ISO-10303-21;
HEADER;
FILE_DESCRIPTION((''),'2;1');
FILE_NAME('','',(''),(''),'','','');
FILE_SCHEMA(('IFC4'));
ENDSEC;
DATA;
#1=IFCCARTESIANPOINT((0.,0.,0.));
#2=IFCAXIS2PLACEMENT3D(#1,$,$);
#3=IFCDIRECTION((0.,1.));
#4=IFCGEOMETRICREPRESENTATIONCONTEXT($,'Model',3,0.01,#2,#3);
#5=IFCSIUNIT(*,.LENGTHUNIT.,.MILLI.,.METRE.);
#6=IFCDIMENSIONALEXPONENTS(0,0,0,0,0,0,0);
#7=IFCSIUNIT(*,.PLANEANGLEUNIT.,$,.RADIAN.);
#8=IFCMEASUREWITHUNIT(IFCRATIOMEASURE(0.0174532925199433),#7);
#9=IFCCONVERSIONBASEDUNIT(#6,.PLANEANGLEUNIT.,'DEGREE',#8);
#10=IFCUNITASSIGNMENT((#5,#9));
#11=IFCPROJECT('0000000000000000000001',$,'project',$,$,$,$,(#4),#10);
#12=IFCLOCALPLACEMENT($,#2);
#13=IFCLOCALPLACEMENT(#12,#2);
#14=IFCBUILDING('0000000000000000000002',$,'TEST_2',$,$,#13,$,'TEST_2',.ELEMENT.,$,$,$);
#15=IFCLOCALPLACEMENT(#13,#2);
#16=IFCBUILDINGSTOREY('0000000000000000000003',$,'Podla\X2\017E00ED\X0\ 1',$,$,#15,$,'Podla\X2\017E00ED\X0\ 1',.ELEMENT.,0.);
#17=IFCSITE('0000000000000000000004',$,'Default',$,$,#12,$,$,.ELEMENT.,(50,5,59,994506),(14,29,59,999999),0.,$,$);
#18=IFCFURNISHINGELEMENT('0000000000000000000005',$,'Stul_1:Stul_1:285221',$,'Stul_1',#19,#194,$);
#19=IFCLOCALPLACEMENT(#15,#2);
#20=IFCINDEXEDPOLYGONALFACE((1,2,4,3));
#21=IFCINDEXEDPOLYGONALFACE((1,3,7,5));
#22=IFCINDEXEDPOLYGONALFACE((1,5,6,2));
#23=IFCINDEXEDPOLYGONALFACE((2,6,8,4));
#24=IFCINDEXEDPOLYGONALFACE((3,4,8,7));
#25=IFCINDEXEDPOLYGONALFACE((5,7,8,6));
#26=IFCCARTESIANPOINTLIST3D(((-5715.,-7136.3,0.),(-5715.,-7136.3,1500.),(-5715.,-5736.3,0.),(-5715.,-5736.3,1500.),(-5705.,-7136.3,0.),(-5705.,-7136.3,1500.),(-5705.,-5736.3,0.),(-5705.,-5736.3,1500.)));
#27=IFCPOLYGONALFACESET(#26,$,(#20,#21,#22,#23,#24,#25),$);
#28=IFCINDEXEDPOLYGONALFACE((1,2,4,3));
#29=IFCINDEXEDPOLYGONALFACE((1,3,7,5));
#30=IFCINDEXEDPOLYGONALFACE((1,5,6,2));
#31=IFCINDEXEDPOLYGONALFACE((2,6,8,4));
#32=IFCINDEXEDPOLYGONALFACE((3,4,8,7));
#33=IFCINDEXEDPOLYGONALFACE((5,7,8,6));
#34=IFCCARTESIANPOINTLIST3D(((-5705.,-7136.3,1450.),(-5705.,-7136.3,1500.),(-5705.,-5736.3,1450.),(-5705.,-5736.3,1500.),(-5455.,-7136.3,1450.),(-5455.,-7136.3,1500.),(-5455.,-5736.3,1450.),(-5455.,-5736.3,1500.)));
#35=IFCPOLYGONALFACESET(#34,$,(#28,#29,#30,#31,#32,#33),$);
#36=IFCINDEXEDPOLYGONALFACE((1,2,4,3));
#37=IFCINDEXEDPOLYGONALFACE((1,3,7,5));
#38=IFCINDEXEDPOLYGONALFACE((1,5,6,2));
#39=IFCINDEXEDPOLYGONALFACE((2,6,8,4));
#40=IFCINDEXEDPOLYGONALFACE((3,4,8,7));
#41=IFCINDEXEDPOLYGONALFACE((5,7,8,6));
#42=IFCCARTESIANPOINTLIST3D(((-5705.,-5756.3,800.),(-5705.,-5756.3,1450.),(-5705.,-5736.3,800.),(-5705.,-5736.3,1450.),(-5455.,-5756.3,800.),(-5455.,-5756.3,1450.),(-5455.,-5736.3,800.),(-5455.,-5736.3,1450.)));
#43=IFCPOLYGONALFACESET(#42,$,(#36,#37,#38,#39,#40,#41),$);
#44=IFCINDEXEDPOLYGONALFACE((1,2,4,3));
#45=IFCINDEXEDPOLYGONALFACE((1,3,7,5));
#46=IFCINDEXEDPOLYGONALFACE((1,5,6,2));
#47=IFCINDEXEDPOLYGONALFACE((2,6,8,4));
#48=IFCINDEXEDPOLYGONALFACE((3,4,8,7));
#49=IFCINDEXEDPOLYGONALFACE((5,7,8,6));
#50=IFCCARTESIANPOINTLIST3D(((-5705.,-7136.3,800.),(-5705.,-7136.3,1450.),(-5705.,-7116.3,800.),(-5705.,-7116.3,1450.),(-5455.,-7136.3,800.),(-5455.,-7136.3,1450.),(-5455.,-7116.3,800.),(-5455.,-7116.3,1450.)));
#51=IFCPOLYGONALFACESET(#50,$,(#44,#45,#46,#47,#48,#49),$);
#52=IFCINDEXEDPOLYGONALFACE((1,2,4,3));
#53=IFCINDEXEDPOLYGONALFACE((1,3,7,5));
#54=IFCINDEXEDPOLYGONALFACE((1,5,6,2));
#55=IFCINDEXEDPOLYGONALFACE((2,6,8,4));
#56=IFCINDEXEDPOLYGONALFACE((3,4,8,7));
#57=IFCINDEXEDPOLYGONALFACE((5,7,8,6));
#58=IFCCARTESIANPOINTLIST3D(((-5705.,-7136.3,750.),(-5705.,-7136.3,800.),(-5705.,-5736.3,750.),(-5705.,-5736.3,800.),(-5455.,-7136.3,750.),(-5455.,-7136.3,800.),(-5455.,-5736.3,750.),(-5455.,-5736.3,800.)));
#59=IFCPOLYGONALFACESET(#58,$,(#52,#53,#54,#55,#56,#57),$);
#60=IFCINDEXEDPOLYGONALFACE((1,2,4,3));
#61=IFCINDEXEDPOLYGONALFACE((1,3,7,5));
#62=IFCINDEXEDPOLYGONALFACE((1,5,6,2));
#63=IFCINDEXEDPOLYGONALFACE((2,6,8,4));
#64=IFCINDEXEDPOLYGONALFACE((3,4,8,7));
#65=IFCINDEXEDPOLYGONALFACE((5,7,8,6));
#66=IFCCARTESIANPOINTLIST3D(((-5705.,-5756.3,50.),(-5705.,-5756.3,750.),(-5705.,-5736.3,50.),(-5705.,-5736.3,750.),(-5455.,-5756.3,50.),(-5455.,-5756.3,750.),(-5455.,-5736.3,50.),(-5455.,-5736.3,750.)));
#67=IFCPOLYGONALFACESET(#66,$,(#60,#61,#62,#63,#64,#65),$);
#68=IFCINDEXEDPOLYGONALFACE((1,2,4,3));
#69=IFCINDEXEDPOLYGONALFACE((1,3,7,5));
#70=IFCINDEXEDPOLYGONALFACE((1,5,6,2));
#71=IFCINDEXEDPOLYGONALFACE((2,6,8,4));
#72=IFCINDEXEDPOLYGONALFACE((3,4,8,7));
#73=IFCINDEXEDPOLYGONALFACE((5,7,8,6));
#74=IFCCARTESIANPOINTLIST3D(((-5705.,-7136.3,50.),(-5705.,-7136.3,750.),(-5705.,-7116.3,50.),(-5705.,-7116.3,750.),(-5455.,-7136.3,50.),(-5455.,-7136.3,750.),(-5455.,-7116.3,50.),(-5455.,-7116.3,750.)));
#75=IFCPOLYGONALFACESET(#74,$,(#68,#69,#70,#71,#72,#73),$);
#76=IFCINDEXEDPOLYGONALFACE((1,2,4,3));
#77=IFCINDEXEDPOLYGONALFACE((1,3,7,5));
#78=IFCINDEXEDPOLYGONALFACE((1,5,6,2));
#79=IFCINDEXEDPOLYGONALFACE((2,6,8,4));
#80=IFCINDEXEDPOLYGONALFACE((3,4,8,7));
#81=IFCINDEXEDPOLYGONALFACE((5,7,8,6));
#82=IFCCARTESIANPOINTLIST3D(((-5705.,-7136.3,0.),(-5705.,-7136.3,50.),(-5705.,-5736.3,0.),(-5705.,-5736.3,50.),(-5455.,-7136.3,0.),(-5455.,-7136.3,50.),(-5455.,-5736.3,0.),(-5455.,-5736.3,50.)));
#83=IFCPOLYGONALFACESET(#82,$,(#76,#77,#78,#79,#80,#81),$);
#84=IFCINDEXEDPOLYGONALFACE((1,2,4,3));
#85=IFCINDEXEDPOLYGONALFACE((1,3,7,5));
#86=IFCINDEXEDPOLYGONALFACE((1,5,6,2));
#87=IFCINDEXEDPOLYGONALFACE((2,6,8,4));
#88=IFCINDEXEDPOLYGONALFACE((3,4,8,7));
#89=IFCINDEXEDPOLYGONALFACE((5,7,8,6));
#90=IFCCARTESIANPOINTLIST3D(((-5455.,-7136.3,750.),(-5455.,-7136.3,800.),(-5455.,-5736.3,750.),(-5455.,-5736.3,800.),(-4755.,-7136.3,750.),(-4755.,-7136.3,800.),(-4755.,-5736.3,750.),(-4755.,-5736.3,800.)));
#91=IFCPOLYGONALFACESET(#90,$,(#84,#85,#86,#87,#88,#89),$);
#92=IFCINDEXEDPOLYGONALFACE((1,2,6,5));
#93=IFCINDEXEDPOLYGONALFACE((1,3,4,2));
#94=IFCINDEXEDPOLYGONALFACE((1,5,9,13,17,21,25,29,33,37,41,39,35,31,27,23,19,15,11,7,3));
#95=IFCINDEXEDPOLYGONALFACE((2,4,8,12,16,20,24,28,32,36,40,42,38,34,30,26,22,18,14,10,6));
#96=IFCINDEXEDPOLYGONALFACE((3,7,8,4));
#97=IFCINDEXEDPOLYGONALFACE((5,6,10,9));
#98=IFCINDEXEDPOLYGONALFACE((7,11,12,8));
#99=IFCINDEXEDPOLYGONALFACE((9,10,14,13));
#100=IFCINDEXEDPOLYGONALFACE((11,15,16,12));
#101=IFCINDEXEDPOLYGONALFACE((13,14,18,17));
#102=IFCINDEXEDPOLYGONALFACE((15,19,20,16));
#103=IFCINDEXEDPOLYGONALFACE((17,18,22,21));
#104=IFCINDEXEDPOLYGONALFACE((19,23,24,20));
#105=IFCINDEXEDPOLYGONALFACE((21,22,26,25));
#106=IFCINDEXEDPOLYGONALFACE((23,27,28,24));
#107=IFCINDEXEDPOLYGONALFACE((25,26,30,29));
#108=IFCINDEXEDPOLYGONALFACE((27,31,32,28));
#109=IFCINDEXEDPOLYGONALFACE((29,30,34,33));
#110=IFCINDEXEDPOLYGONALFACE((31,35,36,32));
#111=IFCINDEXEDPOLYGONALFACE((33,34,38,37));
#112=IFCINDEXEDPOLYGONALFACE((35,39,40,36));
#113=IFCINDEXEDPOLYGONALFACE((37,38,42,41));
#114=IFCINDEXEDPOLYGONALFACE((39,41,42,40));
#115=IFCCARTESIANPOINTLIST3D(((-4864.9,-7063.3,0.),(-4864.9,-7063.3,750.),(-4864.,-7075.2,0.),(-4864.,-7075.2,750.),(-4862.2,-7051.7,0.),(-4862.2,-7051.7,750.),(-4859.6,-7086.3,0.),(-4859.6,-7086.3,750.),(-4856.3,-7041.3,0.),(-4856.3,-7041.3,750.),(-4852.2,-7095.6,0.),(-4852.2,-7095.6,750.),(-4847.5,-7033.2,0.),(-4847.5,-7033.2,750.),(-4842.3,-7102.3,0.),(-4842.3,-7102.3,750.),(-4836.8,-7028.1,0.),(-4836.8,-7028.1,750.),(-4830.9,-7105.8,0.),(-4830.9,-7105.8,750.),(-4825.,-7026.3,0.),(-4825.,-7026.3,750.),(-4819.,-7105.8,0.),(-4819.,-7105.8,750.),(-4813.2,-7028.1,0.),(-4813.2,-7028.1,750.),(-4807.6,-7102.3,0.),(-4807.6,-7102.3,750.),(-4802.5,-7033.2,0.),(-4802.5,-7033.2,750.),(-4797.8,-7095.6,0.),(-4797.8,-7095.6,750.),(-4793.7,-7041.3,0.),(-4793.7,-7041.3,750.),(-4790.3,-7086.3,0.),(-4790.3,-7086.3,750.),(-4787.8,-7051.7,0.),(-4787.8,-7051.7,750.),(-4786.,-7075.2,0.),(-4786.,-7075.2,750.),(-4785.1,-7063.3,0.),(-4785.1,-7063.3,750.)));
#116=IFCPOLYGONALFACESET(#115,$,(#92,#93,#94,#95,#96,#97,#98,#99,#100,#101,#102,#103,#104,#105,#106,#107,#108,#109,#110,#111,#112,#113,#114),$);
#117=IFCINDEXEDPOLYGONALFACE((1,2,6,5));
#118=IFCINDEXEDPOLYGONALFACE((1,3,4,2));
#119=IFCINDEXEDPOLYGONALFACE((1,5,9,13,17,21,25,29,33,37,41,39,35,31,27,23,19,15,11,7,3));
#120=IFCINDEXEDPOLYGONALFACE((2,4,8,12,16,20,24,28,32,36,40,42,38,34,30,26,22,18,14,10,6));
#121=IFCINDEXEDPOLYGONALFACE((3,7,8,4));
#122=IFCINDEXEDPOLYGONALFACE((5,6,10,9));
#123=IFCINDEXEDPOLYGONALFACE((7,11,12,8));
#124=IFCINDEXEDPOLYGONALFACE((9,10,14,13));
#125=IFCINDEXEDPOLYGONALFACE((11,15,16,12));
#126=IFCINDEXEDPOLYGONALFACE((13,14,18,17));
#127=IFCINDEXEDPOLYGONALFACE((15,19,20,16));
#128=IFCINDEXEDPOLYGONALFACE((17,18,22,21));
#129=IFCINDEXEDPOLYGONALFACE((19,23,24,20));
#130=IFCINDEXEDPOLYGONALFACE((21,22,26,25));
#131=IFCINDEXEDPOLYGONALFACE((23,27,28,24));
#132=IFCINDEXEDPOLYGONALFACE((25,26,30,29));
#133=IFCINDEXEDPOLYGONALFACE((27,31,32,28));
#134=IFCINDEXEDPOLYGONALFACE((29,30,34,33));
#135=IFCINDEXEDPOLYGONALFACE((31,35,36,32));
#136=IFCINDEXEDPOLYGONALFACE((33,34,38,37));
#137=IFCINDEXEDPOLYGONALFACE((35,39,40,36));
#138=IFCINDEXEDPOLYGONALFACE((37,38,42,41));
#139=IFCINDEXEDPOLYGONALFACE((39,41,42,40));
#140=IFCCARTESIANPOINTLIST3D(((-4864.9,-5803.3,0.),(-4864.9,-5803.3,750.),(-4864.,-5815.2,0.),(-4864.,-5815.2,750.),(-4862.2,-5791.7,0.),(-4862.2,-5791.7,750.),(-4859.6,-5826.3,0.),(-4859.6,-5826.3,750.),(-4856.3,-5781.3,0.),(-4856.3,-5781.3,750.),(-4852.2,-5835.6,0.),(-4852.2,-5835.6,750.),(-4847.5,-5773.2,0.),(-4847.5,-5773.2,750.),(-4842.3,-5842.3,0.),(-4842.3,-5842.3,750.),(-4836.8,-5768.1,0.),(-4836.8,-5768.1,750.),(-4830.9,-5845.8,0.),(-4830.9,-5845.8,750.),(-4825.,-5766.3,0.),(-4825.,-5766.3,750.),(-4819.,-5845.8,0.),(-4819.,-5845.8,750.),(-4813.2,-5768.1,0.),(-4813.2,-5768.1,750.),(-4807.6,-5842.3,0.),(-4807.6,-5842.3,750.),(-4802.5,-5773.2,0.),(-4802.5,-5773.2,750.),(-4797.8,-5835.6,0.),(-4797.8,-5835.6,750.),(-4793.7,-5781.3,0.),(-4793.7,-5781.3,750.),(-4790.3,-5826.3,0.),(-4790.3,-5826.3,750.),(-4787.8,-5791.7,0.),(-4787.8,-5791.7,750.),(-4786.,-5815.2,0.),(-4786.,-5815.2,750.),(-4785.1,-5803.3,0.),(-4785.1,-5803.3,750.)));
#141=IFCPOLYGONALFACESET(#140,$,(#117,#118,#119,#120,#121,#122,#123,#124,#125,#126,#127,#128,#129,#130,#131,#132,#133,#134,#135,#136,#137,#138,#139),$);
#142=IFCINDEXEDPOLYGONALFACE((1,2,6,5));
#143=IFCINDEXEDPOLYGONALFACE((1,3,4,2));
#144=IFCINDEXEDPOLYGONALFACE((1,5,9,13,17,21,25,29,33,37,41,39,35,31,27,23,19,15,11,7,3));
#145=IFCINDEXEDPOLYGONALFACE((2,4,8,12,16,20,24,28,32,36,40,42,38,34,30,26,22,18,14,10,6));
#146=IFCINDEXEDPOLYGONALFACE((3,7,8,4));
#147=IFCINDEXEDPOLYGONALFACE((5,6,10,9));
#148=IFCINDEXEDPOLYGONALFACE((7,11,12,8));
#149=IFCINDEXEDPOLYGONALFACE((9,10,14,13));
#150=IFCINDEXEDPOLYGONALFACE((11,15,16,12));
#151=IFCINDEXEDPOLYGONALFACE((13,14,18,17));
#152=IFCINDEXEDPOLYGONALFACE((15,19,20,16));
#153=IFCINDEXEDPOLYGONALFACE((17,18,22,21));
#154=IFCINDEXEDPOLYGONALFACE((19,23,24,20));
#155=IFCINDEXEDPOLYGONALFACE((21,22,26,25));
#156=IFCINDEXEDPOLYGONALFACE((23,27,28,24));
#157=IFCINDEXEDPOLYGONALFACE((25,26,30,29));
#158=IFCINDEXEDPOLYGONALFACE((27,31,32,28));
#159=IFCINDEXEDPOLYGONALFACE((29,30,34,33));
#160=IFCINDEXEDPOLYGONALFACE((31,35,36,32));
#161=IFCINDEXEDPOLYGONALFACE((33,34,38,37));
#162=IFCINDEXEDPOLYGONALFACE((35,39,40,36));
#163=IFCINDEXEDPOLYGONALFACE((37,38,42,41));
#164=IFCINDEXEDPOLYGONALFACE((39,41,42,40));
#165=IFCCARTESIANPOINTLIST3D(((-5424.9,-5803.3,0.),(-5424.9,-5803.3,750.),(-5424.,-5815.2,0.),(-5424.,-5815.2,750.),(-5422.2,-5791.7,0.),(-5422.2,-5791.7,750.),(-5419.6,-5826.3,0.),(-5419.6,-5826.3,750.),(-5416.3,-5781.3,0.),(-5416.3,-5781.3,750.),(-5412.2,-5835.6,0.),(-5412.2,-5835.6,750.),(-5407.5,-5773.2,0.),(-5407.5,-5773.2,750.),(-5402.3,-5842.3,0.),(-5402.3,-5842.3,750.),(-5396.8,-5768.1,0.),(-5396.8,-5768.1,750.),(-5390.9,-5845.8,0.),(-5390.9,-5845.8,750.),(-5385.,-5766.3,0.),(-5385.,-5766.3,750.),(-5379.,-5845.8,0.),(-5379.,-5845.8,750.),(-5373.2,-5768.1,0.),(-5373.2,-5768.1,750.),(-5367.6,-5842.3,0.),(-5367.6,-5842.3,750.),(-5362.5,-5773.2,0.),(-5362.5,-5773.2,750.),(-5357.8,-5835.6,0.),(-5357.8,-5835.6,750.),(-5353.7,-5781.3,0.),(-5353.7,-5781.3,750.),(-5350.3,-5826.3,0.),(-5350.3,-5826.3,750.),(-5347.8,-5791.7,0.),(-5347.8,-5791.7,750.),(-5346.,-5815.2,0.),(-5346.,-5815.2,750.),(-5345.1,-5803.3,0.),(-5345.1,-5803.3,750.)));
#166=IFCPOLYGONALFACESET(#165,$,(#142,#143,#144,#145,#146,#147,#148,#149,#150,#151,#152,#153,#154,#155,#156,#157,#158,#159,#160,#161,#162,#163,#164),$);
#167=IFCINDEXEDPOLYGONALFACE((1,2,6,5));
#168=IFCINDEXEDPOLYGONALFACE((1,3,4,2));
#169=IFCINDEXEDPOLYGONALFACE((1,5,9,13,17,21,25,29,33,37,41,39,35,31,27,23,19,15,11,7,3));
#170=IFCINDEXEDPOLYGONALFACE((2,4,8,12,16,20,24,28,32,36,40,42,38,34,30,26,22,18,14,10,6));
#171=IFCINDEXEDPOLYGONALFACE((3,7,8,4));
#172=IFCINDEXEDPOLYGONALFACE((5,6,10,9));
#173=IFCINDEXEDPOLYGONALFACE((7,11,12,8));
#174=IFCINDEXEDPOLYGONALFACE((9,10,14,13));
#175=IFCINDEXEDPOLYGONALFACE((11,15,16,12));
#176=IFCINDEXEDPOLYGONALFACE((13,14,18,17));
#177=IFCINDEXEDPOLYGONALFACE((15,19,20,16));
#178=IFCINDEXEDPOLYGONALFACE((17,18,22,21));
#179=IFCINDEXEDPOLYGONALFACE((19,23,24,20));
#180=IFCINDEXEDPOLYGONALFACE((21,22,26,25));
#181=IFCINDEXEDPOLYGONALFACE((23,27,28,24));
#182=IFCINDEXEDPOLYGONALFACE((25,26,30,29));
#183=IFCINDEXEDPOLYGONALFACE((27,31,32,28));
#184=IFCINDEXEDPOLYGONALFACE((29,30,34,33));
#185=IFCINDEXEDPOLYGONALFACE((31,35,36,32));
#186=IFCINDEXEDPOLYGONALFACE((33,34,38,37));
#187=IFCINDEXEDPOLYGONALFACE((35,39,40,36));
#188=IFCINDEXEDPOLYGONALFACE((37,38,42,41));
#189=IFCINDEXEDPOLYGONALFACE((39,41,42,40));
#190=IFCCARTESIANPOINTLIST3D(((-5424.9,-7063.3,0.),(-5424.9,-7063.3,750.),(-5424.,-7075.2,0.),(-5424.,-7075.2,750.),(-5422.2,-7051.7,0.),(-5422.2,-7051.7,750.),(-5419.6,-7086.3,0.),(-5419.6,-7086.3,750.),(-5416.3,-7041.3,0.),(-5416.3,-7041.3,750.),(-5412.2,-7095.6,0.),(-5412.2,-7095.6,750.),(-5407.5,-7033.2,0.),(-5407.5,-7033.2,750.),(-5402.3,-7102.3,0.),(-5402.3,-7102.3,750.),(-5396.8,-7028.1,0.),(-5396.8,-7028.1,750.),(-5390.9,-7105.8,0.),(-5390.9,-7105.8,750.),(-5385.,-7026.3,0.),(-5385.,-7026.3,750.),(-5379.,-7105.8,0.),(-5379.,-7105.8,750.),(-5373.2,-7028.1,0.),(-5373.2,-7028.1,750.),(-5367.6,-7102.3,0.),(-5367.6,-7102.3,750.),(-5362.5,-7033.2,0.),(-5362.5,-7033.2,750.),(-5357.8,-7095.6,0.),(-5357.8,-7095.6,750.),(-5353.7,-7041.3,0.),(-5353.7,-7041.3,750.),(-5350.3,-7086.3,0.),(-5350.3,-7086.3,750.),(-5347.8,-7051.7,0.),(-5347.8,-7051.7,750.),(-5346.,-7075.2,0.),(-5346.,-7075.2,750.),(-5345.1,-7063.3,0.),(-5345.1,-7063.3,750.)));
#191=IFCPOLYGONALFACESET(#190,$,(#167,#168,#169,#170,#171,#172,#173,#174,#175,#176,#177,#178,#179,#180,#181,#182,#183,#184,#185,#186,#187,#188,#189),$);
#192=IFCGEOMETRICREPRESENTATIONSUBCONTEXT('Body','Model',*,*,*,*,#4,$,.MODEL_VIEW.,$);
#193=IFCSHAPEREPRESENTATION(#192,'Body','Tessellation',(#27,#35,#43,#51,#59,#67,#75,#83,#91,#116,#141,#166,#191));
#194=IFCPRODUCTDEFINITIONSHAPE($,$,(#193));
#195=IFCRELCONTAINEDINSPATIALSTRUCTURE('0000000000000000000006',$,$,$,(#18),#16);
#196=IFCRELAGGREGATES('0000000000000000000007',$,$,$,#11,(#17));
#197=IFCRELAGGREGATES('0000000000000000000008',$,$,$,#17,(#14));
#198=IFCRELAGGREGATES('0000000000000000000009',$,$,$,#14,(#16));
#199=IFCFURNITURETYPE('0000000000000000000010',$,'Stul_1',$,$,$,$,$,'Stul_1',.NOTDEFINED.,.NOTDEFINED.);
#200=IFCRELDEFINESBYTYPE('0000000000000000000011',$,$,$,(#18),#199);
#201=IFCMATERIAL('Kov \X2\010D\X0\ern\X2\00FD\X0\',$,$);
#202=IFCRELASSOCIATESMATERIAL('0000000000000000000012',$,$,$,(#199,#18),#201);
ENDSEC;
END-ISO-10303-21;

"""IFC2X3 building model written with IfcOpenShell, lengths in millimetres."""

from ifc_helpers import new_model, entity, si_unit, converted_unit, direction, frame, frame_2d, origin, origin_2d_with_axis, place, context, subcontext, project, spatial, rectangle, circle, extrude, source, transform, mapped, material, type_object, type_shapes, element, save


model = new_model("IFC2X3")

# Units and contexts
model_context = context("Model", 3, precision=0.01, world=origin(), true_north=direction((0.0, 1.0)))
body_context = subcontext(model_context, "Body", "Model", "MODEL_VIEW")
ifc_project = project(units=[si_unit("LENGTHUNIT", "METRE", prefix="MILLI"), converted_unit("PLANEANGLEUNIT", "DEGREE", entity("IfcRatioMeasure", 0.0174532925199433), si_unit("PLANEANGLEUNIT", "RADIAN"), dimensions=[0, 0, 0, 0, 0, 0, 0])], contexts=[model_context])

# Site, building, storey
site_placement = place(None, origin())
site = spatial("IfcSite", under=ifc_project, at=site_placement, Name="Default", CompositionType="ELEMENT", RefLatitude=(50, 5, 59, 994506), RefLongitude=(14, 29, 59, 999999), RefElevation=0.0)
building_placement = place(site_placement, origin())
building = spatial("IfcBuilding", under=site, at=building_placement, Name="TEST_2", LongName="TEST_2", CompositionType="ELEMENT")
storey_placement = place(building_placement, origin())
storey = spatial("IfcBuildingStorey", under=building, at=storey_placement, Name="Podlaží 1", LongName="Podlaží 1", CompositionType="ELEMENT", Elevation=0.0)

# Furnishing element
ifc_material = material(Name="Kov černý")
furniture_type = type_object("IfcFurnitureType", Name="Stul_1", ElementType="Stul_1", material=ifc_material)
shared_shape = source(origin(), body_context, "Body", "SweptSolid", [
    extrude(rectangle(XDim=1400.0, YDim=10.0, at=origin_2d_with_axis()), frame((0.0, 605.0, 0.0), z_axis=(0.0, 0.0, 1.0), x_axis=(-1.0, 0.0, 0.0)), (0.0, 0.0, 1.0), 1500.0),
    extrude(rectangle(XDim=1400.0, YDim=250.0, at=frame_2d((0.0, 0.0), x_axis=(1.0, 0.0))), frame((0.0, 475.0, 1450.0), z_axis=(0.0, 0.0, 1.0), x_axis=(-1.0, 0.0, 0.0)), (0.0, 0.0, 1.0), 50.0),
    extrude(rectangle(XDim=20.0, YDim=250.0, at=origin_2d_with_axis()), frame((690.0, 475.0, 800.0), z_axis=(0.0, 0.0, 1.0), x_axis=(-1.0, 0.0, 0.0)), (0.0, 0.0, 1.0), 650.0),
    extrude(rectangle(XDim=20.0, YDim=250.0, at=frame_2d((0.0, 0.0), x_axis=(1.0, 0.0))), frame((-690.0, 475.0, 800.0), z_axis=(0.0, 0.0, 1.0), x_axis=(-1.0, 0.0, 0.0)), (0.0, 0.0, 1.0), 650.0),
    extrude(rectangle(XDim=1400.0, YDim=250.0, at=origin_2d_with_axis()), frame((0.0, 475.0, 750.0), z_axis=(0.0, 0.0, 1.0), x_axis=(-1.0, 0.0, 0.0)), (0.0, 0.0, 1.0), 50.0),
    extrude(rectangle(XDim=20.0, YDim=250.0, at=origin_2d_with_axis()), frame((690.0, 475.0, 50.0), z_axis=(0.0, 0.0, 1.0), x_axis=(-1.0, 0.0, 0.0)), (0.0, 0.0, 1.0), 700.0),
    extrude(rectangle(XDim=20.0, YDim=250.0, at=frame_2d((0.0, 0.0), x_axis=(1.0, 0.0))), frame((-690.0, 475.0, 50.0), z_axis=(0.0, 0.0, 1.0), x_axis=(-1.0, 0.0, 0.0)), (0.0, 0.0, 1.0), 700.0),
    extrude(rectangle(XDim=1400.0, YDim=250.0, at=origin_2d_with_axis()), frame((0.0, 475.0, 0.0), z_axis=(0.0, 0.0, 1.0), x_axis=(-1.0, 0.0, 0.0)), (0.0, 0.0, 1.0), 50.0),
    extrude(rectangle(XDim=1400.0, YDim=700.0, at=origin_2d_with_axis()), frame((0.0, 0.0, 750.0), z_axis=(0.0, 0.0, 1.0), x_axis=(-1.0, 0.0, 0.0)), (0.0, 0.0, 1.0), 50.0),
    extrude(circle(Radius=40.0, at=frame_2d((0.0, 0.0), x_axis=(1.0, 0.0))), frame((-630.0, -280.0, 0.0)), (0.0, 0.0, 1.0), 750.0),
    extrude(circle(Radius=40.0, at=frame_2d((0.0, 0.0), x_axis=(1.0, 0.0))), frame((630.0, -280.0, 0.0)), (0.0, 0.0, 1.0), 750.0),
    extrude(circle(Radius=40.0, at=frame_2d((0.0, 0.0), x_axis=(1.0, 0.0))), frame((630.0, 280.0, 0.0)), (0.0, 0.0, 1.0), 750.0),
    extrude(circle(Radius=40.0, at=frame_2d((0.0, 0.0), x_axis=(1.0, 0.0))), frame((-630.0, 280.0, 0.0)), (0.0, 0.0, 1.0), 750.0),
])
type_shapes(furniture_type, [shared_shape])
for number, where, z_axis, x_axis, name in (
    (1, (-5105.0, -6436.3, 0.0), (0.0, 0.0, 1.0), (0.0, 1.0, 0.0), "Stul_1:Stul_1:285221"),
):
    element("IfcFurnishingElement", number, at=place(storey_placement, frame(where, z_axis=z_axis, x_axis=x_axis)), inside=storey, type_object=furniture_type, material=ifc_material, Name=name, ObjectType="Stul_1", context=body_context, shape_type="MappedRepresentation", body=[
        mapped(shared_shape, transform((0.0, 0.0, 0.0), scale=1.0)),
    ])

save(model, "model.ifc")
